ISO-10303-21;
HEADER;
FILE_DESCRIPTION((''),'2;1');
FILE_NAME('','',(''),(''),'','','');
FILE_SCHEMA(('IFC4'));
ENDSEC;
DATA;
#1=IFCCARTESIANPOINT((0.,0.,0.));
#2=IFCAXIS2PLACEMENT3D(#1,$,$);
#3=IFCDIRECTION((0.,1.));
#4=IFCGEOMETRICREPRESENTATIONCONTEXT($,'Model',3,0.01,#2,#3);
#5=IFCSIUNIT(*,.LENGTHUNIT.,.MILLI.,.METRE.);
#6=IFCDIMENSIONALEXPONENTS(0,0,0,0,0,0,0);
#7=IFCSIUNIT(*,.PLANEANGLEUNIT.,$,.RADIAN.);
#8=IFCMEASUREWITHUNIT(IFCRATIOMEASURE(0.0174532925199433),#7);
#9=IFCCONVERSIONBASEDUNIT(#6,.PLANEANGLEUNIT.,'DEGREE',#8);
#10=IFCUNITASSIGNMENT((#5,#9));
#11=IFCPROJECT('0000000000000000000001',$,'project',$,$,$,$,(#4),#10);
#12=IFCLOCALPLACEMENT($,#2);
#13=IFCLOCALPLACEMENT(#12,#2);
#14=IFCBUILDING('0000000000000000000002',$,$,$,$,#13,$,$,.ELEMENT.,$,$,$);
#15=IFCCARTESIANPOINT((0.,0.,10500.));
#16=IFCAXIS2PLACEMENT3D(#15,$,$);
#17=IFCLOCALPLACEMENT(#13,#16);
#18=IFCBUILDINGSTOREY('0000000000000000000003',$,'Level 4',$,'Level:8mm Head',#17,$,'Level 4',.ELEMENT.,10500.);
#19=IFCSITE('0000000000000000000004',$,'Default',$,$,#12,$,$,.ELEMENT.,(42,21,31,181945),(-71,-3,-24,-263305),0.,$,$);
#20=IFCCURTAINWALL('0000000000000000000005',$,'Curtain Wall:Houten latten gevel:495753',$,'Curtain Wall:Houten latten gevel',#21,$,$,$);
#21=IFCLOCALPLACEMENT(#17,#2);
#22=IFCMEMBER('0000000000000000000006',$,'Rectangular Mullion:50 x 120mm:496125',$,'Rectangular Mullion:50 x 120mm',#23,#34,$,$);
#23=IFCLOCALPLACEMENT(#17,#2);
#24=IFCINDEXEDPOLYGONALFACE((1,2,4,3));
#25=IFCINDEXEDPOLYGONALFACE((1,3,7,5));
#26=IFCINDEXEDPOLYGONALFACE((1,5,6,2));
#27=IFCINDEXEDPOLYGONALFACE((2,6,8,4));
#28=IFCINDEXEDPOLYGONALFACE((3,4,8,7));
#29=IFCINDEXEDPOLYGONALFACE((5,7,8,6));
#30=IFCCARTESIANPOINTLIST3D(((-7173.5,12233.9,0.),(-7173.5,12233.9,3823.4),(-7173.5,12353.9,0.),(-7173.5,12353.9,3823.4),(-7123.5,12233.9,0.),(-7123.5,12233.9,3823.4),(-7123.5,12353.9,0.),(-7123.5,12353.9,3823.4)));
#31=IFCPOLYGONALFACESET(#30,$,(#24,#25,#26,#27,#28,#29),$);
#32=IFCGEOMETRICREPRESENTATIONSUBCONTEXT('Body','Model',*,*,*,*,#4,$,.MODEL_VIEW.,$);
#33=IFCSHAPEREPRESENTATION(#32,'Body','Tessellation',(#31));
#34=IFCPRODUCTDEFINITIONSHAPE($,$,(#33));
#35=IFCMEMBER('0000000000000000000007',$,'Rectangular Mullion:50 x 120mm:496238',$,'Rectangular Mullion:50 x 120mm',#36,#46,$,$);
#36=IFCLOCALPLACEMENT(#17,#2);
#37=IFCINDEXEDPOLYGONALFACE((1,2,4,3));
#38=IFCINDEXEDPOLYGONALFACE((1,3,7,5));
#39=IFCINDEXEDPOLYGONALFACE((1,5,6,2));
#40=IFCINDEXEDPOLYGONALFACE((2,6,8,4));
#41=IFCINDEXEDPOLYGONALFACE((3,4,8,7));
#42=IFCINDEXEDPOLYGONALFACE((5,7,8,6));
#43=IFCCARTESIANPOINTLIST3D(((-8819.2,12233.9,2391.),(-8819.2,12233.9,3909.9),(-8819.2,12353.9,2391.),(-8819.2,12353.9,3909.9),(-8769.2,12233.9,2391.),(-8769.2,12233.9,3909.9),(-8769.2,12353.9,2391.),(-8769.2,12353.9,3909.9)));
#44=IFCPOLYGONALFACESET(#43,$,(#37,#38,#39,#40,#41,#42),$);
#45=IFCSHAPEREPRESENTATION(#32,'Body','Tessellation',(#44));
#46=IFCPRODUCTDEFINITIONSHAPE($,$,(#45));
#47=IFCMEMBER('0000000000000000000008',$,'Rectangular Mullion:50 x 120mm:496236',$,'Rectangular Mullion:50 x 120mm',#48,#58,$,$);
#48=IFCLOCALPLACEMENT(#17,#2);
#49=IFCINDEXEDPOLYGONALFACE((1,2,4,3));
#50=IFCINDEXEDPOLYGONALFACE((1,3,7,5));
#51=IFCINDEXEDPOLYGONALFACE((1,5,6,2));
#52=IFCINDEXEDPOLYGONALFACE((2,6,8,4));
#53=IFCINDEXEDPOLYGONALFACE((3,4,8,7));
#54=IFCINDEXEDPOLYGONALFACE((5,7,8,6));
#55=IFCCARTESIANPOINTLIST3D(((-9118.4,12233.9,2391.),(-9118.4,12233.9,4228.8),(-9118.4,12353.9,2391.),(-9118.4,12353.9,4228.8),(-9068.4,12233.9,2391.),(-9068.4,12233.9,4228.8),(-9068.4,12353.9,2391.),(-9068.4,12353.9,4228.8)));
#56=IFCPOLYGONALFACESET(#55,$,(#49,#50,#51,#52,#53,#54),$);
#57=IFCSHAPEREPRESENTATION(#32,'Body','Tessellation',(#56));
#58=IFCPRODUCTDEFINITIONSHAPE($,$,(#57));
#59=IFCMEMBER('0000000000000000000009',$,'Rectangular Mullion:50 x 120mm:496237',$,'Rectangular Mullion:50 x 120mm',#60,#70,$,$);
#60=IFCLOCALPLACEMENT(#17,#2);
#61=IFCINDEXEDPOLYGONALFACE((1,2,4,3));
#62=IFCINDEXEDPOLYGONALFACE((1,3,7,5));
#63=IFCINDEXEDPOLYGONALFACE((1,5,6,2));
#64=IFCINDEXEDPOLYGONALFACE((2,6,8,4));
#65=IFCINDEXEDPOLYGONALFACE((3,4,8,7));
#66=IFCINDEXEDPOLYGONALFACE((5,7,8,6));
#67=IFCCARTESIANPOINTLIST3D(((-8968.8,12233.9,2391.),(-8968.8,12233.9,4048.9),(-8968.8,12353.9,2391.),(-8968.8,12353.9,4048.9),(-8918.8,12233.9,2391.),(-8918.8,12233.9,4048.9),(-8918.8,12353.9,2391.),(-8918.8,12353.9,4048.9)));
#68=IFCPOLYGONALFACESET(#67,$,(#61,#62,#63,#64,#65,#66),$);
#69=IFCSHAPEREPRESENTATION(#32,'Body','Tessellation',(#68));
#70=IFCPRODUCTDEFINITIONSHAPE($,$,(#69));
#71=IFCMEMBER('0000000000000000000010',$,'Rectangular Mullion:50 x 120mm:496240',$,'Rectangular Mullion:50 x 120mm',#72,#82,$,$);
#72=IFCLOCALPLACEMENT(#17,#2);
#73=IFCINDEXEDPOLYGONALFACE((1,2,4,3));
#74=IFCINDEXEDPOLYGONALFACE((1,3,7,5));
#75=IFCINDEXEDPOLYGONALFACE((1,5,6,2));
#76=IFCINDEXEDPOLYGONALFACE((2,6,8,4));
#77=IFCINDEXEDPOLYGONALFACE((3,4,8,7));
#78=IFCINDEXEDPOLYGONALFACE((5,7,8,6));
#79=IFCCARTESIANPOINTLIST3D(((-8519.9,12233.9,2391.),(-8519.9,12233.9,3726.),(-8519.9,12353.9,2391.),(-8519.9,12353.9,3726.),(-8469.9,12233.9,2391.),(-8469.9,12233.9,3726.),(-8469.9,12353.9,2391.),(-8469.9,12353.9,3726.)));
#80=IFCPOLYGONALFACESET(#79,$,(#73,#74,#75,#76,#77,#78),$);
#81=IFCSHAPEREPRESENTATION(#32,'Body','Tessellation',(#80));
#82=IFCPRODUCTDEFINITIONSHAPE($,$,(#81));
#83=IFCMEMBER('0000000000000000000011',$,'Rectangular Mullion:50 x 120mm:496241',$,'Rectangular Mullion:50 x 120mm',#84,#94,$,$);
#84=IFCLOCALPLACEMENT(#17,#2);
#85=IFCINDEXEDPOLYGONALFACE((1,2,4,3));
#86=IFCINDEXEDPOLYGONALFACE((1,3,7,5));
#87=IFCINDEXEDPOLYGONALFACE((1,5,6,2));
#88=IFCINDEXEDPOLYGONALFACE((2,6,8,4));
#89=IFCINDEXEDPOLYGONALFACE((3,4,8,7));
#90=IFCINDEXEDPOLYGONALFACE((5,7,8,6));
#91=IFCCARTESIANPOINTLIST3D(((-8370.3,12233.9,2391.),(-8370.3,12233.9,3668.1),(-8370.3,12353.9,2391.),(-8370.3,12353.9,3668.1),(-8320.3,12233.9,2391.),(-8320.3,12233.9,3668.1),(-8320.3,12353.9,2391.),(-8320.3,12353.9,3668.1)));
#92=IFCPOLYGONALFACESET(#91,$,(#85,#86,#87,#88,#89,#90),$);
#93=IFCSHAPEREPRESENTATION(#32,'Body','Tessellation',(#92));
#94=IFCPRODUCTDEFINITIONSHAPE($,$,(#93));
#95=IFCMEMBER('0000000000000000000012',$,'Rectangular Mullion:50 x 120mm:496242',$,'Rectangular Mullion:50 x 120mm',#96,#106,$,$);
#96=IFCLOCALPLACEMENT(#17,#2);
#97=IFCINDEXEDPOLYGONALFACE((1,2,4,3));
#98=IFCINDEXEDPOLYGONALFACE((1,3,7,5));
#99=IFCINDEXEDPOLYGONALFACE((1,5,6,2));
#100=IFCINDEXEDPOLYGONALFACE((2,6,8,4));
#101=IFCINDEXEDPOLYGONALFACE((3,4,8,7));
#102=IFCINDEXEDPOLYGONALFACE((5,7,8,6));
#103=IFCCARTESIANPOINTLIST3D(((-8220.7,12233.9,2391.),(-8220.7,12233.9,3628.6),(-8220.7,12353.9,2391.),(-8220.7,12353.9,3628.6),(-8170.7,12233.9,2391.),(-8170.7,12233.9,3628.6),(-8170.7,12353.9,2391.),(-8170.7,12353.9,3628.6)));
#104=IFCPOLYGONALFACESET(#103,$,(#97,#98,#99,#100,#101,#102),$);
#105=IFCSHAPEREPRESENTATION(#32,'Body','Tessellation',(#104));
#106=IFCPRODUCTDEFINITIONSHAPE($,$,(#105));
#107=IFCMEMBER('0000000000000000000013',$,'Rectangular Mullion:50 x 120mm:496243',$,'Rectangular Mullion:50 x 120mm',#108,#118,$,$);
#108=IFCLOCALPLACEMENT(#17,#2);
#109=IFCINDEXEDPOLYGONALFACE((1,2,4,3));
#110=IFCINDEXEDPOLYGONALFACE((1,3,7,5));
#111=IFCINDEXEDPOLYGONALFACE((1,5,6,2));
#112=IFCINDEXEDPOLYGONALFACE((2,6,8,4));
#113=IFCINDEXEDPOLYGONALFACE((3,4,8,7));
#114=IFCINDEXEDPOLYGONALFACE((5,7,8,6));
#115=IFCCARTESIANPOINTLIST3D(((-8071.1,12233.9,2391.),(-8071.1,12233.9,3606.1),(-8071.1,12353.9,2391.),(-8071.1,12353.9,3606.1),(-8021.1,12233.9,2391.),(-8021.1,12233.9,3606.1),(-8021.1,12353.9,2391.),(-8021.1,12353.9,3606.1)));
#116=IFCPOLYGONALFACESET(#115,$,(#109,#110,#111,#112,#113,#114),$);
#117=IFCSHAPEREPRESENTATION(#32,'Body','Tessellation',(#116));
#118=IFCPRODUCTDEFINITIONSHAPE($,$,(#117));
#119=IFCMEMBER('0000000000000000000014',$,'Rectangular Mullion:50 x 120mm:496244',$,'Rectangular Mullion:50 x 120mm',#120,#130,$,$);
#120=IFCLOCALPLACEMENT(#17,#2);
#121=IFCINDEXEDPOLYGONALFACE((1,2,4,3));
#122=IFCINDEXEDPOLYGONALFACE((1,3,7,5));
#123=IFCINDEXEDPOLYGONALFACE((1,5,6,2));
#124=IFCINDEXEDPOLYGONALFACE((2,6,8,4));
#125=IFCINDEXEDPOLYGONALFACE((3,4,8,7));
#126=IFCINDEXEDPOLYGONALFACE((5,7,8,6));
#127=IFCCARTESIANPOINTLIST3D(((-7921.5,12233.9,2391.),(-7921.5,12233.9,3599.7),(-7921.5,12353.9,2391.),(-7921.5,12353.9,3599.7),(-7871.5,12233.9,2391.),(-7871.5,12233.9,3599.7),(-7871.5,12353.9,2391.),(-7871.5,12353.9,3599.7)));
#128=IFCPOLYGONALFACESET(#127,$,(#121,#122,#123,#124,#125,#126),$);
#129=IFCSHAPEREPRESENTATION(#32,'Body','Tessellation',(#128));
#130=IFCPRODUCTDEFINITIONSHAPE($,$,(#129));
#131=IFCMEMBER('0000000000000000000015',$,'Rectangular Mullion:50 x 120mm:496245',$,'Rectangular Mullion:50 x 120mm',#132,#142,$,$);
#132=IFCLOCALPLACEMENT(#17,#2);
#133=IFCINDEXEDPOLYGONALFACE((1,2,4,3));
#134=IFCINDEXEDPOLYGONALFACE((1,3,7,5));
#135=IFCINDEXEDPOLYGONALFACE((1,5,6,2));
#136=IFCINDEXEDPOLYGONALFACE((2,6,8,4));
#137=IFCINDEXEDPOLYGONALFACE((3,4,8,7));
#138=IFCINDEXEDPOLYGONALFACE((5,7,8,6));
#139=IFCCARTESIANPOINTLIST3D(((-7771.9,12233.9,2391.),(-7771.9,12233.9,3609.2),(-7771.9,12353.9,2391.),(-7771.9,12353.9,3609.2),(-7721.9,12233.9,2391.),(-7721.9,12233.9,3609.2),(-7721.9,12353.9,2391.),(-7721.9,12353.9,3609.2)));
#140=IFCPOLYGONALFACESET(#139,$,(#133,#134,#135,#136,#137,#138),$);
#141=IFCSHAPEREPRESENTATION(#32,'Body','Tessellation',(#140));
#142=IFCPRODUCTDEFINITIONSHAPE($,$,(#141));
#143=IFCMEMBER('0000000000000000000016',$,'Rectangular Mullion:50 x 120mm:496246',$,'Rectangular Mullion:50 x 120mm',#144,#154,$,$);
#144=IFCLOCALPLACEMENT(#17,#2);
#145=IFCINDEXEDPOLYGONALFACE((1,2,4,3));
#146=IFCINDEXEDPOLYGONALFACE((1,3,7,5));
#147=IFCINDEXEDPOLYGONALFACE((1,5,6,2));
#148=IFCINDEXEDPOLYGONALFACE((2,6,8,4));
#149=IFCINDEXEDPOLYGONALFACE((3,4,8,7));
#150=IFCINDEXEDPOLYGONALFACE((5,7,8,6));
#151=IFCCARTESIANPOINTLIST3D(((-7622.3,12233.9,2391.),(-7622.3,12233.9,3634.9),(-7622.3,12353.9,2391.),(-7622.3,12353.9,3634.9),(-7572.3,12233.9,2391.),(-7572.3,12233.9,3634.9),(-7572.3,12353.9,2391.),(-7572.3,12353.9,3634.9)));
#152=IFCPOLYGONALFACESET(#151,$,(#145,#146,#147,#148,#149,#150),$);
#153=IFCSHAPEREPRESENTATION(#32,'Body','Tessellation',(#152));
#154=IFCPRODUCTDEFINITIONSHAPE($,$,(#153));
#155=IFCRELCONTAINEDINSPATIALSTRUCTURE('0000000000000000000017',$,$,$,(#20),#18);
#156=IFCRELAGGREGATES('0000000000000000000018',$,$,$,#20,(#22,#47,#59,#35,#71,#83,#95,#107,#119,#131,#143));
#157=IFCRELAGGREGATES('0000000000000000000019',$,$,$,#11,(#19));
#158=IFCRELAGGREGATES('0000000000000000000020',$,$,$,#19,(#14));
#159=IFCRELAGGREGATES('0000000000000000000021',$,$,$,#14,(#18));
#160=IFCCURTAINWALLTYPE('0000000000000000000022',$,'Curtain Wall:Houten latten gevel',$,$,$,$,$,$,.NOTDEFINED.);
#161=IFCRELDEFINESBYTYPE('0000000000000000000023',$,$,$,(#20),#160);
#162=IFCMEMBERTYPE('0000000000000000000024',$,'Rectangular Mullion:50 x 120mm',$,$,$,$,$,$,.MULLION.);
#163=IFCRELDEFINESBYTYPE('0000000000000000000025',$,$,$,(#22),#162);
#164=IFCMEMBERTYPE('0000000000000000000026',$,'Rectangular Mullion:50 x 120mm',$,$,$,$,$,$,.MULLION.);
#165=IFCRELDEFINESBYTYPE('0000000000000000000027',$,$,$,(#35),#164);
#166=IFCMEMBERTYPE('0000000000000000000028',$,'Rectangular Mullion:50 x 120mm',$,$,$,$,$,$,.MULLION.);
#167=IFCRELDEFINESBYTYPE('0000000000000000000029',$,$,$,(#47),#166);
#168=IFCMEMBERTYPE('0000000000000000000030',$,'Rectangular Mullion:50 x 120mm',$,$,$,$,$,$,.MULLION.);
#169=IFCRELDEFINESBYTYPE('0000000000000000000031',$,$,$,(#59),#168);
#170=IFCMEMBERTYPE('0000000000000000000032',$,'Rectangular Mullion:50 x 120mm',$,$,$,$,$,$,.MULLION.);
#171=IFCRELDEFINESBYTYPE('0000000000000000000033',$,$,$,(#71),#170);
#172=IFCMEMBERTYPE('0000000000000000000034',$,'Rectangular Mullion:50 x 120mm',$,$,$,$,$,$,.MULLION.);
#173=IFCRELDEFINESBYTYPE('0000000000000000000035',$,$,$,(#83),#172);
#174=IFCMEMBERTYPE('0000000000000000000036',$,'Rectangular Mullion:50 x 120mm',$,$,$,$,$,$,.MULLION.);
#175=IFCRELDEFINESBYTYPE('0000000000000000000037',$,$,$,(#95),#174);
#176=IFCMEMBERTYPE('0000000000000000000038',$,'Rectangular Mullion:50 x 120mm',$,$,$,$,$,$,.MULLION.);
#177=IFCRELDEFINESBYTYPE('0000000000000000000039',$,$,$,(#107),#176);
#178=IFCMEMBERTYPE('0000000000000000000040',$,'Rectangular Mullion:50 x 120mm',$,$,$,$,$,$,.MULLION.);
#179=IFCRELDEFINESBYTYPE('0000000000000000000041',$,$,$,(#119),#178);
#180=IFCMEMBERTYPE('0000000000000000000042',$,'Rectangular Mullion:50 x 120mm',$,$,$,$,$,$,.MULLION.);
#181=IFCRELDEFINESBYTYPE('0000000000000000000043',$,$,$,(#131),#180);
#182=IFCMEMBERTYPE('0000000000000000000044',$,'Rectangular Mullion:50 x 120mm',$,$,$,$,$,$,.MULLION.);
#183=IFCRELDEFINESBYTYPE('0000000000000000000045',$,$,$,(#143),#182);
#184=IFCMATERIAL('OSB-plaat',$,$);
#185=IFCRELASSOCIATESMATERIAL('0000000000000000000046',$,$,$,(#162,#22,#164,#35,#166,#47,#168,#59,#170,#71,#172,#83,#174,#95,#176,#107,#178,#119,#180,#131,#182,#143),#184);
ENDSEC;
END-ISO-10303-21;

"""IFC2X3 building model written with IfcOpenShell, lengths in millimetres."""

from ifc_helpers import new_model, entity, si_unit, converted_unit, direction, frame, origin, origin_2d_with_axis, place, context, subcontext, project, spatial, rectangle, extrude, source, transform, mapped, material, type_object, type_shapes, element, aggregate, save


model = new_model("IFC2X3")

# Units and contexts
model_context = context("Model", 3, precision=0.01, world=origin(), true_north=direction((0.0, 1.0)))
body_context = subcontext(model_context, "Body", "Model", "MODEL_VIEW")
ifc_project = project(units=[si_unit("LENGTHUNIT", "METRE", prefix="MILLI"), converted_unit("PLANEANGLEUNIT", "DEGREE", entity("IfcRatioMeasure", 0.0174532925199433), si_unit("PLANEANGLEUNIT", "RADIAN"), dimensions=[0, 0, 0, 0, 0, 0, 0])], contexts=[model_context])

# Site, building, storey
site_placement = place(None, frame((0.0, 0.0, 0.0)))
site = spatial("IfcSite", under=ifc_project, at=site_placement, Name="Default", CompositionType="ELEMENT", RefLatitude=(42, 21, 31, 181945), RefLongitude=(-71, -3, -24, -263305), RefElevation=0.0)
building_placement = place(site_placement, origin())
building = spatial("IfcBuilding", under=site, at=building_placement, CompositionType="ELEMENT")
storey_placement = place(building_placement, frame((0.0, 0.0, 10500.0)))
storey = spatial("IfcBuildingStorey", under=building, at=storey_placement, Name="Level 4", ObjectType="Level:8mm Head", LongName="Level 4", CompositionType="ELEMENT", Elevation=10500.0)

# Curtain wall, members
curtain_wall_type = type_object("IfcCurtainWallType", Name="Curtain Wall:Houten latten gevel", PredefinedType="NOTDEFINED")
curtain_wall_placement = place(storey_placement, frame((0.0, 0.0, -10500.0)))
curtain_wall = element("IfcCurtainWall", 1, at=curtain_wall_placement, inside=storey, type_object=curtain_wall_type, Name="Curtain Wall:Houten latten gevel:495753", ObjectType="Curtain Wall:Houten latten gevel")
ifc_material = material(Name="OSB-plaat")
placement = place(building_placement, frame((0.0, 0.0, 7500.0)))
member_type_1 = type_object("IfcMemberType", Name="Rectangular Mullion:50 x 120mm", PredefinedType="MULLION", material=ifc_material)
shared_shape_1 = source(origin(), body_context, "Body", "SweptSolid", [
    extrude(rectangle(XDim=120.0, YDim=50.0, at=origin_2d_with_axis()), frame((0.0, 0.0, -3823.4), z_axis=(0.0, 0.0, 1.0), x_axis=(0.0, -1.0, 0.0)), (0.0, 0.0, 1.0), 3823.4),
])
type_shapes(member_type_1, [shared_shape_1])
member_1_placement = place(placement, frame((-7148.5, 12293.9, 3000.0), z_axis=(0.0, 0.0, -1.0), x_axis=(1.0, 0.0, 0.0)))
member_1 = element("IfcMember", 2, at=member_1_placement, type_object=member_type_1, material=ifc_material, Name="Rectangular Mullion:50 x 120mm:496125", ObjectType="Rectangular Mullion:50 x 120mm", context=body_context, shape_type="MappedRepresentation", body=[
    mapped(shared_shape_1, transform((0.0, 0.0, 0.0), scale=1.0)),
])
member_type_2 = type_object("IfcMemberType", Name="Rectangular Mullion:50 x 120mm", PredefinedType="MULLION", material=ifc_material)
shared_shape_2 = source(origin(), body_context, "Body", "SweptSolid", [
    extrude(rectangle(XDim=120.0, YDim=50.0, at=origin_2d_with_axis()), frame((0.0, 0.0, -1518.9), z_axis=(0.0, 0.0, 1.0), x_axis=(0.0, -1.0, 0.0)), (0.0, 0.0, 1.0), 1518.9),
])
type_shapes(member_type_2, [shared_shape_2])
member_2_placement = place(placement, frame((-8794.2, 12293.9, 5391.0), z_axis=(0.0, 0.0, -1.0), x_axis=(1.0, 0.0, 0.0)))
member_2 = element("IfcMember", 3, at=member_2_placement, type_object=member_type_2, material=ifc_material, Name="Rectangular Mullion:50 x 120mm:496238", ObjectType="Rectangular Mullion:50 x 120mm", context=body_context, shape_type="MappedRepresentation", body=[
    mapped(shared_shape_2, transform((0.0, 0.0, 0.0), scale=1.0)),
])
member_type_3 = type_object("IfcMemberType", Name="Rectangular Mullion:50 x 120mm", PredefinedType="MULLION", material=ifc_material)
shared_shape_3 = source(origin(), body_context, "Body", "SweptSolid", [
    extrude(rectangle(XDim=120.0, YDim=50.0, at=origin_2d_with_axis()), frame((0.0, 0.0, -1837.8), z_axis=(0.0, 0.0, 1.0), x_axis=(0.0, -1.0, 0.0)), (0.0, 0.0, 1.0), 1837.8),
])
type_shapes(member_type_3, [shared_shape_3])
member_3_placement = place(placement, frame((-9093.4, 12293.9, 5391.0), z_axis=(0.0, 0.0, -1.0), x_axis=(1.0, 0.0, 0.0)))
member_3 = element("IfcMember", 4, at=member_3_placement, type_object=member_type_3, material=ifc_material, Name="Rectangular Mullion:50 x 120mm:496236", ObjectType="Rectangular Mullion:50 x 120mm", context=body_context, shape_type="MappedRepresentation", body=[
    mapped(shared_shape_3, transform((0.0, 0.0, 0.0), scale=1.0)),
])
member_type_4 = type_object("IfcMemberType", Name="Rectangular Mullion:50 x 120mm", PredefinedType="MULLION", material=ifc_material)
shared_shape_4 = source(origin(), body_context, "Body", "SweptSolid", [
    extrude(rectangle(XDim=120.0, YDim=50.0, at=origin_2d_with_axis()), frame((0.0, 0.0, -1657.9), z_axis=(0.0, 0.0, 1.0), x_axis=(0.0, -1.0, 0.0)), (0.0, 0.0, 1.0), 1657.9),
])
type_shapes(member_type_4, [shared_shape_4])
member_4_placement = place(placement, frame((-8943.8, 12293.9, 5391.0), z_axis=(0.0, 0.0, -1.0), x_axis=(1.0, 0.0, 0.0)))
member_4 = element("IfcMember", 5, at=member_4_placement, type_object=member_type_4, material=ifc_material, Name="Rectangular Mullion:50 x 120mm:496237", ObjectType="Rectangular Mullion:50 x 120mm", context=body_context, shape_type="MappedRepresentation", body=[
    mapped(shared_shape_4, transform((0.0, 0.0, 0.0), scale=1.0)),
])
member_type_5 = type_object("IfcMemberType", Name="Rectangular Mullion:50 x 120mm", PredefinedType="MULLION", material=ifc_material)
shared_shape_5 = source(origin(), body_context, "Body", "SweptSolid", [
    extrude(rectangle(XDim=120.0, YDim=50.0, at=origin_2d_with_axis()), frame((0.0, 0.0, -1335.0), z_axis=(0.0, 0.0, 1.0), x_axis=(0.0, -1.0, 0.0)), (0.0, 0.0, 1.0), 1335.0),
])
type_shapes(member_type_5, [shared_shape_5])
member_5_placement = place(placement, frame((-8494.9, 12293.9, 5391.0), z_axis=(0.0, 0.0, -1.0), x_axis=(1.0, 0.0, 0.0)))
member_5 = element("IfcMember", 6, at=member_5_placement, type_object=member_type_5, material=ifc_material, Name="Rectangular Mullion:50 x 120mm:496240", ObjectType="Rectangular Mullion:50 x 120mm", context=body_context, shape_type="MappedRepresentation", body=[
    mapped(shared_shape_5, transform((0.0, 0.0, 0.0), scale=1.0)),
])
member_type_6 = type_object("IfcMemberType", Name="Rectangular Mullion:50 x 120mm", PredefinedType="MULLION", material=ifc_material)
shared_shape_6 = source(origin(), body_context, "Body", "SweptSolid", [
    extrude(rectangle(XDim=120.0, YDim=50.0, at=origin_2d_with_axis()), frame((0.0, 0.0, -1277.1), z_axis=(0.0, 0.0, 1.0), x_axis=(0.0, -1.0, 0.0)), (0.0, 0.0, 1.0), 1277.1),
])
type_shapes(member_type_6, [shared_shape_6])
member_6_placement = place(placement, frame((-8345.3, 12293.9, 5391.0), z_axis=(0.0, 0.0, -1.0), x_axis=(1.0, 0.0, 0.0)))
member_6 = element("IfcMember", 7, at=member_6_placement, type_object=member_type_6, material=ifc_material, Name="Rectangular Mullion:50 x 120mm:496241", ObjectType="Rectangular Mullion:50 x 120mm", context=body_context, shape_type="MappedRepresentation", body=[
    mapped(shared_shape_6, transform((0.0, 0.0, 0.0), scale=1.0)),
])
member_type_7 = type_object("IfcMemberType", Name="Rectangular Mullion:50 x 120mm", PredefinedType="MULLION", material=ifc_material)
shared_shape_7 = source(origin(), body_context, "Body", "SweptSolid", [
    extrude(rectangle(XDim=120.0, YDim=50.0, at=origin_2d_with_axis()), frame((0.0, 0.0, -1237.6), z_axis=(0.0, 0.0, 1.0), x_axis=(0.0, -1.0, 0.0)), (0.0, 0.0, 1.0), 1237.6),
])
type_shapes(member_type_7, [shared_shape_7])
member_7_placement = place(placement, frame((-8195.7, 12293.9, 5391.0), z_axis=(0.0, 0.0, -1.0), x_axis=(1.0, 0.0, 0.0)))
member_7 = element("IfcMember", 8, at=member_7_placement, type_object=member_type_7, material=ifc_material, Name="Rectangular Mullion:50 x 120mm:496242", ObjectType="Rectangular Mullion:50 x 120mm", context=body_context, shape_type="MappedRepresentation", body=[
    mapped(shared_shape_7, transform((0.0, 0.0, 0.0), scale=1.0)),
])
member_type_8 = type_object("IfcMemberType", Name="Rectangular Mullion:50 x 120mm", PredefinedType="MULLION", material=ifc_material)
shared_shape_8 = source(origin(), body_context, "Body", "SweptSolid", [
    extrude(rectangle(XDim=120.0, YDim=50.0, at=origin_2d_with_axis()), frame((0.0, 0.0, -1215.1), z_axis=(0.0, 0.0, 1.0), x_axis=(0.0, -1.0, 0.0)), (0.0, 0.0, 1.0), 1215.1),
])
type_shapes(member_type_8, [shared_shape_8])
member_8_placement = place(placement, frame((-8046.1, 12293.9, 5391.0), z_axis=(0.0, 0.0, -1.0), x_axis=(1.0, 0.0, 0.0)))
member_8 = element("IfcMember", 9, at=member_8_placement, type_object=member_type_8, material=ifc_material, Name="Rectangular Mullion:50 x 120mm:496243", ObjectType="Rectangular Mullion:50 x 120mm", context=body_context, shape_type="MappedRepresentation", body=[
    mapped(shared_shape_8, transform((0.0, 0.0, 0.0), scale=1.0)),
])
member_type_9 = type_object("IfcMemberType", Name="Rectangular Mullion:50 x 120mm", PredefinedType="MULLION", material=ifc_material)
shared_shape_9 = source(origin(), body_context, "Body", "SweptSolid", [
    extrude(rectangle(XDim=120.0, YDim=50.0, at=origin_2d_with_axis()), frame((0.0, 0.0, -1208.7), z_axis=(0.0, 0.0, 1.0), x_axis=(0.0, -1.0, 0.0)), (0.0, 0.0, 1.0), 1208.7),
])
type_shapes(member_type_9, [shared_shape_9])
member_9_placement = place(placement, frame((-7896.5, 12293.9, 5391.0), z_axis=(0.0, 0.0, -1.0), x_axis=(1.0, 0.0, 0.0)))
member_9 = element("IfcMember", 10, at=member_9_placement, type_object=member_type_9, material=ifc_material, Name="Rectangular Mullion:50 x 120mm:496244", ObjectType="Rectangular Mullion:50 x 120mm", context=body_context, shape_type="MappedRepresentation", body=[
    mapped(shared_shape_9, transform((0.0, 0.0, 0.0), scale=1.0)),
])
member_type_10 = type_object("IfcMemberType", Name="Rectangular Mullion:50 x 120mm", PredefinedType="MULLION", material=ifc_material)
shared_shape_10 = source(origin(), body_context, "Body", "SweptSolid", [
    extrude(rectangle(XDim=120.0, YDim=50.0, at=origin_2d_with_axis()), frame((0.0, 0.0, -1218.2), z_axis=(0.0, 0.0, 1.0), x_axis=(0.0, -1.0, 0.0)), (0.0, 0.0, 1.0), 1218.2),
])
type_shapes(member_type_10, [shared_shape_10])
member_10_placement = place(placement, frame((-7746.9, 12293.9, 5391.0), z_axis=(0.0, 0.0, -1.0), x_axis=(1.0, 0.0, 0.0)))
member_10 = element("IfcMember", 11, at=member_10_placement, type_object=member_type_10, material=ifc_material, Name="Rectangular Mullion:50 x 120mm:496245", ObjectType="Rectangular Mullion:50 x 120mm", context=body_context, shape_type="MappedRepresentation", body=[
    mapped(shared_shape_10, transform((0.0, 0.0, 0.0), scale=1.0)),
])
member_type_11 = type_object("IfcMemberType", Name="Rectangular Mullion:50 x 120mm", PredefinedType="MULLION", material=ifc_material)
shared_shape_11 = source(origin(), body_context, "Body", "SweptSolid", [
    extrude(rectangle(XDim=120.0, YDim=50.0, at=origin_2d_with_axis()), frame((0.0, 0.0, -1243.9), z_axis=(0.0, 0.0, 1.0), x_axis=(0.0, -1.0, 0.0)), (0.0, 0.0, 1.0), 1243.9),
])
type_shapes(member_type_11, [shared_shape_11])
member_11_placement = place(placement, frame((-7597.3, 12293.9, 5391.0), z_axis=(0.0, 0.0, -1.0), x_axis=(1.0, 0.0, 0.0)))
member_11 = element("IfcMember", 12, at=member_11_placement, type_object=member_type_11, material=ifc_material, Name="Rectangular Mullion:50 x 120mm:496246", ObjectType="Rectangular Mullion:50 x 120mm", context=body_context, shape_type="MappedRepresentation", body=[
    mapped(shared_shape_11, transform((0.0, 0.0, 0.0), scale=1.0)),
])
aggregate(curtain_wall, [member_1, member_3, member_4, member_2, member_5, member_6, member_7, member_8, member_9, member_10, member_11])

save(model, "model.ifc")
